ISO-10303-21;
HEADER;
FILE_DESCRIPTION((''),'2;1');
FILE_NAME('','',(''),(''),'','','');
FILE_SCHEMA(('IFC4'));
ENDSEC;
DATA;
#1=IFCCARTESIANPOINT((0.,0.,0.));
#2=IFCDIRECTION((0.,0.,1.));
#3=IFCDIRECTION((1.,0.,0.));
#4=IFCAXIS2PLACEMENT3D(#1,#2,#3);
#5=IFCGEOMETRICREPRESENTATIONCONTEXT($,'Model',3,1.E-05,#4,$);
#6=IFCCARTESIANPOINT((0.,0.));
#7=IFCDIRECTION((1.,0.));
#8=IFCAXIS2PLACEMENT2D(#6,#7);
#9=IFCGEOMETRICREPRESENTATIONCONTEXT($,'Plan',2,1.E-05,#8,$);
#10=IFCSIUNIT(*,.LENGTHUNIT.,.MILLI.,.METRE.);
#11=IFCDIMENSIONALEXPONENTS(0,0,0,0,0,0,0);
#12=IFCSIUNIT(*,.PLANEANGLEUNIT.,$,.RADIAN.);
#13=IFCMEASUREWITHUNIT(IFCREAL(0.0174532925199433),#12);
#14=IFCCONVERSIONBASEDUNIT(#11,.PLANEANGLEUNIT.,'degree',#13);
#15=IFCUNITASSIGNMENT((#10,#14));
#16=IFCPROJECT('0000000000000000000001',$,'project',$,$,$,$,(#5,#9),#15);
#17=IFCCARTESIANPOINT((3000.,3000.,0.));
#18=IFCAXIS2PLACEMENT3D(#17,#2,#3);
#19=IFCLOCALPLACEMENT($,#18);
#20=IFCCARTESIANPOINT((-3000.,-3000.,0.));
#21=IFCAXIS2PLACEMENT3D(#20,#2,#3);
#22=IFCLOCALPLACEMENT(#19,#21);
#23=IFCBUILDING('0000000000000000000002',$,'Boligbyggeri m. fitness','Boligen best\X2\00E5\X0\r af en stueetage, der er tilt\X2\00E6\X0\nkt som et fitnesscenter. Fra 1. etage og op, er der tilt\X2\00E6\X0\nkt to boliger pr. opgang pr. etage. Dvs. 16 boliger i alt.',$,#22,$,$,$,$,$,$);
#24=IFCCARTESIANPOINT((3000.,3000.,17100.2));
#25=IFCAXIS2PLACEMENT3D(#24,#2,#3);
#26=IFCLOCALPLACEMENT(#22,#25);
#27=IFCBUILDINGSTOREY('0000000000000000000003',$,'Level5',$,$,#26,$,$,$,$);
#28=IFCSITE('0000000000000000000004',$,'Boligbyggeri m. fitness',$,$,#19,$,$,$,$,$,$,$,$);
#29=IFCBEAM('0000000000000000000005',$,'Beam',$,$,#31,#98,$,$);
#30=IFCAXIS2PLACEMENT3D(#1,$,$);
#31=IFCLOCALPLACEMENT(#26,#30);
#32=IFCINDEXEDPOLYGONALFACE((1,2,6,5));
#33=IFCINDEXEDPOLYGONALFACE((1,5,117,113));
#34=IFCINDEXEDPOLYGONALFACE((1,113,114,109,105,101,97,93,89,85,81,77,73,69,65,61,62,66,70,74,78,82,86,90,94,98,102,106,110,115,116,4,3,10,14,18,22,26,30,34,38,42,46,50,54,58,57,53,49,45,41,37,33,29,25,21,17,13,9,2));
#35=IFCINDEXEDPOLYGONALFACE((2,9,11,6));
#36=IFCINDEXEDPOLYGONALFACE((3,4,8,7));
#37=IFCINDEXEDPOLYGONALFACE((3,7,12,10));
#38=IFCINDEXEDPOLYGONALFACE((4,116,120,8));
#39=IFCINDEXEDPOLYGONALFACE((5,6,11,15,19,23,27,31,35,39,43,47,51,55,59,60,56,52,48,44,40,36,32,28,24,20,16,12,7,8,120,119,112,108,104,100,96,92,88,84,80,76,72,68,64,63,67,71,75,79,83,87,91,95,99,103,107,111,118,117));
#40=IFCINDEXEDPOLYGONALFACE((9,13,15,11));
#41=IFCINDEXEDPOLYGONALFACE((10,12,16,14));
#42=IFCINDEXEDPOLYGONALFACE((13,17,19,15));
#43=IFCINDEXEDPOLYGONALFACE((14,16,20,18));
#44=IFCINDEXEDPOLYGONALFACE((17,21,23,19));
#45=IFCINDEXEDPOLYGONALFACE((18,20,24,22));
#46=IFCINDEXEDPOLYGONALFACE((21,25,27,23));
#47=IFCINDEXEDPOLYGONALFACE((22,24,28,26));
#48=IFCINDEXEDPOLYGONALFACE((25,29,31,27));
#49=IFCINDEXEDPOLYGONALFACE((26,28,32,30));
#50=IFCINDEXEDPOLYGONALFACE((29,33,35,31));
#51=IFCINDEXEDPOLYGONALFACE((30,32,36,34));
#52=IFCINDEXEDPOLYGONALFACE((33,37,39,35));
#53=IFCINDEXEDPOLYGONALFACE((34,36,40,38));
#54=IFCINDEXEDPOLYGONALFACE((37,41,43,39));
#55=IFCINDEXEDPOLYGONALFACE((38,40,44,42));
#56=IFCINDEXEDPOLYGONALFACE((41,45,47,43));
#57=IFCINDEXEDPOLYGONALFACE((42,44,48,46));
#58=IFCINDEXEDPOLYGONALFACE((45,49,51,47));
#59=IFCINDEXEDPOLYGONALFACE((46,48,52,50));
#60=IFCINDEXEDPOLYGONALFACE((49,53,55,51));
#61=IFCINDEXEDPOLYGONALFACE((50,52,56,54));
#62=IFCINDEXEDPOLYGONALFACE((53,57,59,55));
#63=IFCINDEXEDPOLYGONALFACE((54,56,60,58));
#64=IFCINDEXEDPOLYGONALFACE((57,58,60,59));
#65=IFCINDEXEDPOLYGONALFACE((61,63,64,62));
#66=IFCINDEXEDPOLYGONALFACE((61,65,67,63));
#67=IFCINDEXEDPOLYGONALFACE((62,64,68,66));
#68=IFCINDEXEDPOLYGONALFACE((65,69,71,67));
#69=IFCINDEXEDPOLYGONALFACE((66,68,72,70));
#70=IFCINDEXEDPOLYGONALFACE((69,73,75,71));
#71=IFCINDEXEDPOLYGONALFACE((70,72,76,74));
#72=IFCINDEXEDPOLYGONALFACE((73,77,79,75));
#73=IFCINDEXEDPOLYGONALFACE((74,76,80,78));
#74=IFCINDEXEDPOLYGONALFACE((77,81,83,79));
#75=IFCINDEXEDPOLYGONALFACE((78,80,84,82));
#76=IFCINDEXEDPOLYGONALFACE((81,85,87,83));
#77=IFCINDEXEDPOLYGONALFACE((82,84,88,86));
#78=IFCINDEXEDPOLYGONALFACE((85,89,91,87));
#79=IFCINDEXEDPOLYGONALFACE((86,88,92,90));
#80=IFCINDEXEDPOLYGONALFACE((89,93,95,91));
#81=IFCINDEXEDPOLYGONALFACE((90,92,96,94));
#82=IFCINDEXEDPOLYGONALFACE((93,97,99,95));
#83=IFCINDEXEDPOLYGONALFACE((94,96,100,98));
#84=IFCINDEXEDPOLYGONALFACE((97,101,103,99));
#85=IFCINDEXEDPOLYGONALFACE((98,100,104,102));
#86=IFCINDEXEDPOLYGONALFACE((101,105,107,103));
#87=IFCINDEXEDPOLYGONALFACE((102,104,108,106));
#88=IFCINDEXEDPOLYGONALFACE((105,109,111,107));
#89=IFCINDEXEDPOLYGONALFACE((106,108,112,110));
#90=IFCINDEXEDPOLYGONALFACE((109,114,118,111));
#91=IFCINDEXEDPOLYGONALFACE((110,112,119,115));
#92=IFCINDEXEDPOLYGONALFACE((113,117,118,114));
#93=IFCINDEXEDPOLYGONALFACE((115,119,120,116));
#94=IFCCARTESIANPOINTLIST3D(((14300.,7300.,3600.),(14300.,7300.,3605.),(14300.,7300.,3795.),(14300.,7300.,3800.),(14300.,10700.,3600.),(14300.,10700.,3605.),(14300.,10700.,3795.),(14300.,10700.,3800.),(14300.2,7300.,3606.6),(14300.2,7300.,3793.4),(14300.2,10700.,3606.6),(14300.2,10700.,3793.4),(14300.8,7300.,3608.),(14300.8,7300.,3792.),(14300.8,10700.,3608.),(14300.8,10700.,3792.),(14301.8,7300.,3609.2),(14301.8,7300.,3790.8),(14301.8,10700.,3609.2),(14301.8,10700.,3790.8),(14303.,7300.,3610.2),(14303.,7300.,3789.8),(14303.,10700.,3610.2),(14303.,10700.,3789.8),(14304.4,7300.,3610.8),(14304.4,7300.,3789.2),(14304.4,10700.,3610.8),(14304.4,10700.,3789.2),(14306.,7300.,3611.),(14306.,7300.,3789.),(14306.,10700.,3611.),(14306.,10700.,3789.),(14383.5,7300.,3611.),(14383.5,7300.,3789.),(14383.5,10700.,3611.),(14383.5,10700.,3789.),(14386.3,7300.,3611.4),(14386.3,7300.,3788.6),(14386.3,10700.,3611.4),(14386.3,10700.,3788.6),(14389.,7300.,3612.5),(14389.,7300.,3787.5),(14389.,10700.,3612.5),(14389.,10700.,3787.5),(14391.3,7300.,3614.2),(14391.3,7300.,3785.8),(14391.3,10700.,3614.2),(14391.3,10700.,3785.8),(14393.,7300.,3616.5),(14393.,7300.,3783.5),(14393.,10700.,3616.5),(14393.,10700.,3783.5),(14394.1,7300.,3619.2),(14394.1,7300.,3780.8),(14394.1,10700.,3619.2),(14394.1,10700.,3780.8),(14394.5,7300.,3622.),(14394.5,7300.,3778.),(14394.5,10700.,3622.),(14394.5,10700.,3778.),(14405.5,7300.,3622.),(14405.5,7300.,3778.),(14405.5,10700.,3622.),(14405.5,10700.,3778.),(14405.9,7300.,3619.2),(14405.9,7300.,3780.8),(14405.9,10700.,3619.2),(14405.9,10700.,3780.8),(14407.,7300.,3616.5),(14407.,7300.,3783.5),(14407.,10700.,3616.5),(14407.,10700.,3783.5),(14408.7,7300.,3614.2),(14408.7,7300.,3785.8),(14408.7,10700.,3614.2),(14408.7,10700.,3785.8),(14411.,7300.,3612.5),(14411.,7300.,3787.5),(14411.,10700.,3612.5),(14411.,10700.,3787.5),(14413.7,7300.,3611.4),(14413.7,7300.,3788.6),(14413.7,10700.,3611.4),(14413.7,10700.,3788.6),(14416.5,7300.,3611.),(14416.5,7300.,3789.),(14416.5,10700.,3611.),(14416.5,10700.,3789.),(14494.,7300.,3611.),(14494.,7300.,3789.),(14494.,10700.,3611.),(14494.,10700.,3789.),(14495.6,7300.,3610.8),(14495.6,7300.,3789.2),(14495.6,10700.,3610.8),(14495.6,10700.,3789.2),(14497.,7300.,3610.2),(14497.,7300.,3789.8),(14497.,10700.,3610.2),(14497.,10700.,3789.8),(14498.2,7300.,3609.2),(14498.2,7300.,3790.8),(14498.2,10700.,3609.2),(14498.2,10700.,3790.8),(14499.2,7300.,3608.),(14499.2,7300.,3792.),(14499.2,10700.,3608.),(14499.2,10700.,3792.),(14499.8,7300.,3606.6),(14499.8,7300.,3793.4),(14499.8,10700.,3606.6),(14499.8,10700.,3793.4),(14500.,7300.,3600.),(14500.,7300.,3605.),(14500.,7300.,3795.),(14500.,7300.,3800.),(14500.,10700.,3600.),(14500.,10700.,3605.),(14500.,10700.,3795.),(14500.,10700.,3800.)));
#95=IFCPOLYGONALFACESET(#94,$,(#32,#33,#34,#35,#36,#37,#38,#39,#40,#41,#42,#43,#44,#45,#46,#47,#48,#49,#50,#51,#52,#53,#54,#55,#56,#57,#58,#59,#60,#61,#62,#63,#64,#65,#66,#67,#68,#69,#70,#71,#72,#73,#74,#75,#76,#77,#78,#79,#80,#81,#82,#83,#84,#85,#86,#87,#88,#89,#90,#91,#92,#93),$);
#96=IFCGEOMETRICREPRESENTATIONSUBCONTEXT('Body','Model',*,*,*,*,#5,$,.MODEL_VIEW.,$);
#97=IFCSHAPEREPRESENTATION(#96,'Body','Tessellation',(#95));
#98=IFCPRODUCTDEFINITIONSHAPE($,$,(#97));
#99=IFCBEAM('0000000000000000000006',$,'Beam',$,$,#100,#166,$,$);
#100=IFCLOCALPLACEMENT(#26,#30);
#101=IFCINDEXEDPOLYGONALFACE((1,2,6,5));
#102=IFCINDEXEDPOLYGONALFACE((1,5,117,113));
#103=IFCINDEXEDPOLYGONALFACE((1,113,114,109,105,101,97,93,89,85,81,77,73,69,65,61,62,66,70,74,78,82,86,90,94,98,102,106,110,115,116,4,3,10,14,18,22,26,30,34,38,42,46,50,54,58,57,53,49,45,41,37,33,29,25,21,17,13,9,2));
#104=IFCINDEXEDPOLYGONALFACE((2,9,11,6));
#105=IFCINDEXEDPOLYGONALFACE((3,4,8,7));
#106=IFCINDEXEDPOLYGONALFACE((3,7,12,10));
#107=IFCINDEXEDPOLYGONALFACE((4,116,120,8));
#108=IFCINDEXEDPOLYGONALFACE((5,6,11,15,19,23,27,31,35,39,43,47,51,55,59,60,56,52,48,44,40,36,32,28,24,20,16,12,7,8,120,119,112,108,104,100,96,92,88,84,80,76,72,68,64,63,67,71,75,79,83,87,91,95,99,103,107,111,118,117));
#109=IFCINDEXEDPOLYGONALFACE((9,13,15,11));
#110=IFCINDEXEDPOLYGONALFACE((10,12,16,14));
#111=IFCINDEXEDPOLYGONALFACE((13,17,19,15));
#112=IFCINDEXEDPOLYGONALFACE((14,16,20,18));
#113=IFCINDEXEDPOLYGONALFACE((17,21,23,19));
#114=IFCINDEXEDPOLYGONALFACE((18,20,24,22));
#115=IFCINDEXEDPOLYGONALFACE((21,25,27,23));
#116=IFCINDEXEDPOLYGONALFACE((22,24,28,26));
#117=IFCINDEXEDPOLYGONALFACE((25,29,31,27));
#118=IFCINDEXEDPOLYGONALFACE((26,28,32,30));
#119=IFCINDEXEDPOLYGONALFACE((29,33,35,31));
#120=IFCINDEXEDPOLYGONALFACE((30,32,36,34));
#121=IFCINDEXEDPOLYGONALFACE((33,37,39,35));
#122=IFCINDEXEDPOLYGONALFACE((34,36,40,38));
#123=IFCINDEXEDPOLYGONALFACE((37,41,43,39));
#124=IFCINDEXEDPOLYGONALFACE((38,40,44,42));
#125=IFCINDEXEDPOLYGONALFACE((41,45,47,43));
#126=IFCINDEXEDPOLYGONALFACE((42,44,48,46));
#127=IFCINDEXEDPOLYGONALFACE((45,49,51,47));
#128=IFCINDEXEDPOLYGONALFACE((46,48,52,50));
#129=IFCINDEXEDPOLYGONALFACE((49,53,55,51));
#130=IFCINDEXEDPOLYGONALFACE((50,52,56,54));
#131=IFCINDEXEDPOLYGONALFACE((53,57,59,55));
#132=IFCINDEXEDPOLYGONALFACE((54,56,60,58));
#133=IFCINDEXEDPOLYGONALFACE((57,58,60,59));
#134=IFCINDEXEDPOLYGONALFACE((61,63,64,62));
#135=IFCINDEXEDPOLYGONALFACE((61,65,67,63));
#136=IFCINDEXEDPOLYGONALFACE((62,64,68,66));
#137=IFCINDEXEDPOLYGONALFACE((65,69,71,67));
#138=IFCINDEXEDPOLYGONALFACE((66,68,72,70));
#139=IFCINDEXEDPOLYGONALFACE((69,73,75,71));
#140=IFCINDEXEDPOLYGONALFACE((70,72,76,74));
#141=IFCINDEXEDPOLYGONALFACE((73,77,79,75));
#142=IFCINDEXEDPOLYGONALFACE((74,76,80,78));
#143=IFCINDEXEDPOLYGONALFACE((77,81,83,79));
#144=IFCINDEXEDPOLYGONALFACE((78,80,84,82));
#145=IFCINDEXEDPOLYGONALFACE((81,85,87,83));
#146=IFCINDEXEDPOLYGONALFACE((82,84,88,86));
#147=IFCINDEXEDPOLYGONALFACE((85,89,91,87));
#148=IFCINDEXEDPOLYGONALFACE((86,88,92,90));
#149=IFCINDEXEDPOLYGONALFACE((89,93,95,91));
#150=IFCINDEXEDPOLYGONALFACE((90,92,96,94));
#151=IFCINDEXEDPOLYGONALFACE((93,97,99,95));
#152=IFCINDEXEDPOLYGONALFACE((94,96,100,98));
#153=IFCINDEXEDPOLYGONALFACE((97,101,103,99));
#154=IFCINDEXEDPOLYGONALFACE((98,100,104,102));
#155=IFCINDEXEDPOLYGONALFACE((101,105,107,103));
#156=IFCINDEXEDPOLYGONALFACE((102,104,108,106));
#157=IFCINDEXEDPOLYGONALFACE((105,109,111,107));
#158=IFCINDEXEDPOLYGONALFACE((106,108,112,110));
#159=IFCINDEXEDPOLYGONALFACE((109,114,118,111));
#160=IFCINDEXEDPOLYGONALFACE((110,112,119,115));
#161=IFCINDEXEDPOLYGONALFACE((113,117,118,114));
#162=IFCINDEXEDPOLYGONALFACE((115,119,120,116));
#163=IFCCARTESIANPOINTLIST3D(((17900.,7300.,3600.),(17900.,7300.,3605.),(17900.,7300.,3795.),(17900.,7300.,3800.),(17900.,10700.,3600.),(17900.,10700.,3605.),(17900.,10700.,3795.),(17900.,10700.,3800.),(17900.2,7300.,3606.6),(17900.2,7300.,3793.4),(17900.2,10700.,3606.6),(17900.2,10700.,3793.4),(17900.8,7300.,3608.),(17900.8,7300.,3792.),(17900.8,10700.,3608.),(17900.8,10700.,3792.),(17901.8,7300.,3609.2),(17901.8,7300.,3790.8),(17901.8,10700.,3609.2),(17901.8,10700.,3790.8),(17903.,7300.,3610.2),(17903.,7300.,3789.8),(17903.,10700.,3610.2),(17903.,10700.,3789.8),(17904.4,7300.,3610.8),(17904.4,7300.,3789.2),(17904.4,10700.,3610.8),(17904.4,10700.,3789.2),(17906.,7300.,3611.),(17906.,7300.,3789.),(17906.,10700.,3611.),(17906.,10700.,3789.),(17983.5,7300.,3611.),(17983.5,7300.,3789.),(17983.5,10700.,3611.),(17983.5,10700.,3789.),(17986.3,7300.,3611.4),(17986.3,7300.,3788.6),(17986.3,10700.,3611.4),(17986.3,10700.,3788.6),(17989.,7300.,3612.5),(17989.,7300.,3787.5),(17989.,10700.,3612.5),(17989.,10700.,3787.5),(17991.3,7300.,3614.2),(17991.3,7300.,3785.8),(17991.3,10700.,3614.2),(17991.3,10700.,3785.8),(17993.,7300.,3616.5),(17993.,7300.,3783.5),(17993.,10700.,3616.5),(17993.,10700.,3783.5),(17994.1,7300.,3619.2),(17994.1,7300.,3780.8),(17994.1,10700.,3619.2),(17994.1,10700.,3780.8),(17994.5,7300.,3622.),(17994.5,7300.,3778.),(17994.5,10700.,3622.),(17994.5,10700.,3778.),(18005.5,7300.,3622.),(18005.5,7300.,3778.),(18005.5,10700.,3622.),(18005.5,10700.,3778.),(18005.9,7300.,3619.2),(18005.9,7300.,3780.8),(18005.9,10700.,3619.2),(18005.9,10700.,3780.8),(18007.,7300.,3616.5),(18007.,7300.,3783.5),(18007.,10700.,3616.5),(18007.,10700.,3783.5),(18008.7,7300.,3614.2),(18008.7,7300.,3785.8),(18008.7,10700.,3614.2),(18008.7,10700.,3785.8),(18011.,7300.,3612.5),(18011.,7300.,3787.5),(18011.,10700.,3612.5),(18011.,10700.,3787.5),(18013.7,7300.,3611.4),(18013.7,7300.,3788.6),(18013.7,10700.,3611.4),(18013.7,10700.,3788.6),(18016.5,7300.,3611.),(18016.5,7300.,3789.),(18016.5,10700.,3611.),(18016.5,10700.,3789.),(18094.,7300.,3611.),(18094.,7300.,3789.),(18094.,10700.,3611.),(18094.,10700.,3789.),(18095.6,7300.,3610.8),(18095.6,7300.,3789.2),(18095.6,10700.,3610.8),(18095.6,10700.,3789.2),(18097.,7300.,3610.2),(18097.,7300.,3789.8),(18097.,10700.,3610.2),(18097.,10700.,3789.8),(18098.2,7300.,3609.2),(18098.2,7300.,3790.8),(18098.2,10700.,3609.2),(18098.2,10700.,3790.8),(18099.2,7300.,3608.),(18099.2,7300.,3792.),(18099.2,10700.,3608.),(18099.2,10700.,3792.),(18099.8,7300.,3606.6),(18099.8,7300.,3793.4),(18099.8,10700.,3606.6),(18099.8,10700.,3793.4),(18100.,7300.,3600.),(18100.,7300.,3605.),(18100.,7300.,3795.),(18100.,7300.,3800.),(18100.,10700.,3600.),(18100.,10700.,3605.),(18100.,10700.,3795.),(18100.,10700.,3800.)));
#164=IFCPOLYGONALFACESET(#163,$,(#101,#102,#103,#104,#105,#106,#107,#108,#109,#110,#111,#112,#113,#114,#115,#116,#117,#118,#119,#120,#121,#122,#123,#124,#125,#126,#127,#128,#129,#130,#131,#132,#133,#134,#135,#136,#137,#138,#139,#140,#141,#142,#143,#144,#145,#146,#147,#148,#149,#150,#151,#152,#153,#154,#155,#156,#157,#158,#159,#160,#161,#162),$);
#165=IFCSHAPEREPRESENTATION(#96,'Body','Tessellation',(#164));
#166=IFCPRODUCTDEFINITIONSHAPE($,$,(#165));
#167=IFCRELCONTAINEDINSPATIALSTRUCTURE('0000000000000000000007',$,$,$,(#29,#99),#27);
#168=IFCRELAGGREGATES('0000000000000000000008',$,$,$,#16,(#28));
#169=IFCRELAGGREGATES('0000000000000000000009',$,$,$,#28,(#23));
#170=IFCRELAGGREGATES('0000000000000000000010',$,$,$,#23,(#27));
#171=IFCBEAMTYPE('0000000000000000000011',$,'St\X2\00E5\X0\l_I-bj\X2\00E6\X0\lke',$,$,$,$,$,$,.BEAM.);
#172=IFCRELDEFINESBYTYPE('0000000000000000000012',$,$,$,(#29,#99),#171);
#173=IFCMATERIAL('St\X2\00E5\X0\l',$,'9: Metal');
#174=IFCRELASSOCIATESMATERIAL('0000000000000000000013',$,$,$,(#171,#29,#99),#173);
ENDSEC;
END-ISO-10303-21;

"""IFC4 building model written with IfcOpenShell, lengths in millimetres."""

from ifc_helpers import new_model, entity, si_unit, converted_unit, frame, origin_with_axes, origin_2d_with_axis, place, context, subcontext, project, spatial, i_section, extrude, material, material_profile, profile_set, profile_usage, type_object, element, save


model = new_model("IFC4")

# Units and contexts
model_context = context("Model", 3, precision=1e-05, world=origin_with_axes())
plan_context = context("Plan", 2, precision=1e-05, world=origin_2d_with_axis())
body_context = subcontext(model_context, "Body", "Model", "MODEL_VIEW")
ifc_project = project(units=[si_unit("LENGTHUNIT", "METRE", prefix="MILLI"), converted_unit("PLANEANGLEUNIT", "degree", entity("IfcReal", 0.0174532925199433), si_unit("PLANEANGLEUNIT", "RADIAN"), dimensions=[0, 0, 0, 0, 0, 0, 0])], contexts=[model_context, plan_context])

# Site, building, storey
site_placement = place(None, frame((3000.0, 3000.0, 0.0), z_axis=(0.0, 0.0, 1.0), x_axis=(1.0, 0.0, 0.0)))
site = spatial("IfcSite", under=ifc_project, at=site_placement, Name="Boligbyggeri m. fitness")
building_placement = place(site_placement, frame((-3000.0, -3000.0, 0.0), z_axis=(0.0, 0.0, 1.0), x_axis=(1.0, 0.0, 0.0)))
building = spatial("IfcBuilding", under=site, at=building_placement, Name="Boligbyggeri m. fitness", Description="Boligen består af en stueetage, der er tiltænkt som et fitnesscenter. Fra 1. etage og op, er der tiltænkt to boliger pr. opgang pr. etage. Dvs. 16 boliger i alt.")
storey_placement = place(building_placement, frame((3000.0, 3000.0, 17100.2), z_axis=(0.0, 0.0, 1.0), x_axis=(1.0, 0.0, 0.0)))
storey = spatial("IfcBuildingStorey", under=building, at=storey_placement, Name="Level5")

# Beams
ifc_material_1 = material(Name="Stål", Category="9: Metal")
ifc_material_profile_1 = material_profile(ifc_material_1, i_section(OverallWidth=200.0, OverallDepth=200.0, WebThickness=11.0, FlangeThickness=11.0, FilletRadius=11.0, FlangeEdgeRadius=6.0), Name="Stål", Category="9: Metal")
ifc_profile_set_1 = profile_set([ifc_material_profile_1], Name="NY_I-Profil")
beam_type = type_object("IfcBeamType", Name="Stål_I-bjælke", PredefinedType="BEAM", material=ifc_profile_set_1)
ifc_profile_usage_1 = profile_usage(ifc_profile_set_1, cardinal=9)
beam_1_placement = place(storey_placement, frame((14500.0, 7300.0, 3800.0), z_axis=(0.0, 1.0, 0.0), x_axis=(-1.0, 0.0, 0.0)))
element("IfcBeam", 1, at=beam_1_placement, inside=storey, type_object=beam_type, material=ifc_profile_usage_1, Name="Beam", context=body_context, shape_type="SweptSolid", body=[
    extrude(i_section(OverallWidth=200.0, OverallDepth=200.0, WebThickness=11.0, FlangeThickness=11.0, FilletRadius=11.0, FlangeEdgeRadius=6.0), frame((100.0, -100.0, 0.0), z_axis=(0.0, 0.0, 1.0), x_axis=(1.0, 0.0, 0.0)), (0.0, 0.0, 1.0), 3400.0),
])
ifc_profile_usage_2 = profile_usage(ifc_profile_set_1, cardinal=9)
beam_2_placement = place(storey_placement, frame((18100.0, 7300.0, 3800.0), z_axis=(0.0, 1.0, 0.0), x_axis=(-1.0, 0.0, 0.0)))
element("IfcBeam", 2, at=beam_2_placement, inside=storey, type_object=beam_type, material=ifc_profile_usage_2, Name="Beam", context=body_context, shape_type="SweptSolid", body=[
    extrude(i_section(OverallWidth=200.0, OverallDepth=200.0, WebThickness=11.0, FlangeThickness=11.0, FilletRadius=11.0, FlangeEdgeRadius=6.0), frame((100.0, -100.0, 0.0), z_axis=(0.0, 0.0, 1.0), x_axis=(1.0, 0.0, 0.0)), (0.0, 0.0, 1.0), 3400.0),
])

save(model, "model.ifc")
